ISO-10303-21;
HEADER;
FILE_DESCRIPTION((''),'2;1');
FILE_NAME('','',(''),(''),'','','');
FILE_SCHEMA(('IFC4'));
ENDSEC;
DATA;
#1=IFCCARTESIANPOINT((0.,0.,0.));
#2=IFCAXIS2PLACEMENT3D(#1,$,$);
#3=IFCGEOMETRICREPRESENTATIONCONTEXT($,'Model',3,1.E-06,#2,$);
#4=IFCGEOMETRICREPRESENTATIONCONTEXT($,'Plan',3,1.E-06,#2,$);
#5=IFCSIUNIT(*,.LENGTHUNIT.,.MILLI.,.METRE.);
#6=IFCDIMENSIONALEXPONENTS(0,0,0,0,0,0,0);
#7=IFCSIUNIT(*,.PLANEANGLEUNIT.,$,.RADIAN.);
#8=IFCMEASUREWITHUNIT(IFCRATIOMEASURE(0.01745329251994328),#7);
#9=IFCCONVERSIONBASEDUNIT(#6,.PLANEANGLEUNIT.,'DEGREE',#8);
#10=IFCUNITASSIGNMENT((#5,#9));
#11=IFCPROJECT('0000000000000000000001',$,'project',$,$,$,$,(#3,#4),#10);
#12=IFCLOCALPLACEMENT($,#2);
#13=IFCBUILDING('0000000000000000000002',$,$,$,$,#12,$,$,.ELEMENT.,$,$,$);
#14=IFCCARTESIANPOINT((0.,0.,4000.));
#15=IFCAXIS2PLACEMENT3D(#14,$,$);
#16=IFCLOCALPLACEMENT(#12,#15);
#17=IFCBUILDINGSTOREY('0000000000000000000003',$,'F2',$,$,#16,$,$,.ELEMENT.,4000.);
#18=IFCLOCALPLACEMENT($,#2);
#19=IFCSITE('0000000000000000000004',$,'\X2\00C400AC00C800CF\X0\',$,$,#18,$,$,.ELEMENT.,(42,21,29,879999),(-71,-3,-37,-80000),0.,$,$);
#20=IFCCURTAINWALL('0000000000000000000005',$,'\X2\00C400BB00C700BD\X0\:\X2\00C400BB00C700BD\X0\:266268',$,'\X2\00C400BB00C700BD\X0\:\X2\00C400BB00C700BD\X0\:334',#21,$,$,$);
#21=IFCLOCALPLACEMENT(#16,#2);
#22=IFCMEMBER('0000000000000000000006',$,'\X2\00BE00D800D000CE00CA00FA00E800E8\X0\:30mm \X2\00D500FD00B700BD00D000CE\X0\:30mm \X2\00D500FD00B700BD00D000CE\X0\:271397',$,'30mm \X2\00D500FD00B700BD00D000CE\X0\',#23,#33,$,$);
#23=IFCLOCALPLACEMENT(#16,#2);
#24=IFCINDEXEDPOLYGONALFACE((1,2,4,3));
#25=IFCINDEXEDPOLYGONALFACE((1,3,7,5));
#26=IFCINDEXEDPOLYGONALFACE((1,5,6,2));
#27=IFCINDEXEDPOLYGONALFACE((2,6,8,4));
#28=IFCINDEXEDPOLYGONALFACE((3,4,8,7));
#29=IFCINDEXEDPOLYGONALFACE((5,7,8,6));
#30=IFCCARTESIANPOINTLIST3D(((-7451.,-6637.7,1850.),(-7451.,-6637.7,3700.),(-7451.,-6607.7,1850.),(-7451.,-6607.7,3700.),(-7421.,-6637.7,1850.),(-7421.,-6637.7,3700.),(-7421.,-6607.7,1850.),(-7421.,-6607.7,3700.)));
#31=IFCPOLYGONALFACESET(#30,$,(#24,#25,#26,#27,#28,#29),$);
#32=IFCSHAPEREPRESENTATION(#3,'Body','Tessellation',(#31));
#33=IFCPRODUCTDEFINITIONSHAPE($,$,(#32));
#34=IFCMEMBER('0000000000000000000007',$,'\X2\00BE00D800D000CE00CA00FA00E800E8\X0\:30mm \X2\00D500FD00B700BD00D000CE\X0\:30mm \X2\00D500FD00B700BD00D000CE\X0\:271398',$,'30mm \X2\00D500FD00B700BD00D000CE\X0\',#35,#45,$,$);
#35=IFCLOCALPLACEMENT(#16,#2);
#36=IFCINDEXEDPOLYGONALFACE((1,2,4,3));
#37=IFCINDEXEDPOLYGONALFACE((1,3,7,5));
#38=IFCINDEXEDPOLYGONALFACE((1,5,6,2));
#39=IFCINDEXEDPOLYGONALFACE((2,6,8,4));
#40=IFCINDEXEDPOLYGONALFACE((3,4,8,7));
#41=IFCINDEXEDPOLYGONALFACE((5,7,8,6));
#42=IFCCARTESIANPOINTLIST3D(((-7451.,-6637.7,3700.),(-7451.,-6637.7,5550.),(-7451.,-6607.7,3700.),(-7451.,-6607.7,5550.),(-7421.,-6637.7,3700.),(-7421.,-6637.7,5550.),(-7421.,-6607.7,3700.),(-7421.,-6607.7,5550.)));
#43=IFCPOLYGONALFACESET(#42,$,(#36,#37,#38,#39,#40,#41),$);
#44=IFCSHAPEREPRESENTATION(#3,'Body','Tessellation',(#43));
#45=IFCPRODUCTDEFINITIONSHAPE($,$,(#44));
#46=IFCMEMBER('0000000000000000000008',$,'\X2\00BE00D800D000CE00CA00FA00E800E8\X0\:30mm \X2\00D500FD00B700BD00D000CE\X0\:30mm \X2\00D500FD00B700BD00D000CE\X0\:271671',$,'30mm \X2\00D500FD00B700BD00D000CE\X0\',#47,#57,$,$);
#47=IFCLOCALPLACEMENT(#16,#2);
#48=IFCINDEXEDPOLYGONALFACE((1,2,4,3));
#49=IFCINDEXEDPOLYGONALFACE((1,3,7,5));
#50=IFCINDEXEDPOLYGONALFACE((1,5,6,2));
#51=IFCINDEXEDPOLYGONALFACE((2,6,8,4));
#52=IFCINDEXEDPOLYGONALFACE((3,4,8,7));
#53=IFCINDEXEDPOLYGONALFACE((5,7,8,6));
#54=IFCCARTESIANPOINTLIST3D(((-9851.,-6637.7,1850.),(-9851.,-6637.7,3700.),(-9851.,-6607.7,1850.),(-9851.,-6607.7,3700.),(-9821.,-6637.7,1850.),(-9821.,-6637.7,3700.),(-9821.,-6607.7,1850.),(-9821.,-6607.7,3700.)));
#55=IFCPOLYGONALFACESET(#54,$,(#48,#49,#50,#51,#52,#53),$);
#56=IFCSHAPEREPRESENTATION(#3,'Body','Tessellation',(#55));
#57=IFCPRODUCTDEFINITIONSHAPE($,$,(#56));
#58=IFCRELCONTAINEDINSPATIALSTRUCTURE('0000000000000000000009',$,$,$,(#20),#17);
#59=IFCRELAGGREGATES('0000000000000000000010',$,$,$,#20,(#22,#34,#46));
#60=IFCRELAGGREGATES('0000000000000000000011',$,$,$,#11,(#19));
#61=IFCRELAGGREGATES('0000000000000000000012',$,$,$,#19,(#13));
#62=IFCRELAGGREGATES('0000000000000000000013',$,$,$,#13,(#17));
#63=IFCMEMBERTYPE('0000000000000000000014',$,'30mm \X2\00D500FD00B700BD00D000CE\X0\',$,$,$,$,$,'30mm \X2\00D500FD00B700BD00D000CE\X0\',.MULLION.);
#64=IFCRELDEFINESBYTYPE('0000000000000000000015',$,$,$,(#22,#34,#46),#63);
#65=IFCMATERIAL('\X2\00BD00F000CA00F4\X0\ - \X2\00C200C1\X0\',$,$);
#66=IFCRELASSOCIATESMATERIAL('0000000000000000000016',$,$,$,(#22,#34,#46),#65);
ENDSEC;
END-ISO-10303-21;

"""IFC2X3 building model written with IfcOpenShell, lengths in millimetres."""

from ifc_helpers import new_model, entity, si_unit, converted_unit, frame, origin, origin_2d_with_axis, place, context, project, spatial, rectangle, extrude, source, transform, mapped, material, type_object, type_shapes, element, aggregate, save


model = new_model("IFC2X3")

# Units and contexts
model_context = context("Model", 3, precision=1e-06, world=origin())
plan_context = context("Plan", 3, precision=1e-06, world=origin())
ifc_project = project(units=[si_unit("LENGTHUNIT", "METRE", prefix="MILLI"), converted_unit("PLANEANGLEUNIT", "DEGREE", entity("IfcRatioMeasure", 0.01745329251994328), si_unit("PLANEANGLEUNIT", "RADIAN"), dimensions=[0, 0, 0, 0, 0, 0, 0])], contexts=[model_context, plan_context])

# Site, building, storey
site_placement = place(None, origin())
site = spatial("IfcSite", under=ifc_project, at=site_placement, Name="Ä¬ÈÏ", CompositionType="ELEMENT", RefLatitude=(42, 21, 29, 879999), RefLongitude=(-71, -3, -37, -80000), RefElevation=0.0)
building_placement = place(None, origin())
building = spatial("IfcBuilding", under=site, at=building_placement, CompositionType="ELEMENT")
storey_placement = place(building_placement, frame((0.0, 0.0, 4000.0)))
storey = spatial("IfcBuildingStorey", under=building, at=storey_placement, Name="F2", CompositionType="ELEMENT", Elevation=4000.0)

# Curtain wall, members
curtain_wall_placement = place(storey_placement, origin())
curtain_wall = element("IfcCurtainWall", 1, at=curtain_wall_placement, inside=storey, Name="Ä»Ç½:Ä»Ç½:266268", ObjectType="Ä»Ç½:Ä»Ç½:334")
ifc_material_1 = material(Name="½ðÊô - ÂÁ")
placement = place(building_placement, frame((0.0, 0.0, 7700.0)))
member_type_1 = type_object("IfcMemberType", Name="30mm Õý·½ÐÎ", ElementType="30mm Õý·½ÐÎ", PredefinedType="MULLION")
shared_shape_1 = source(origin(), model_context, "Body", "SweptSolid", [
    extrude(rectangle(XDim=30.0, YDim=30.0, at=origin_2d_with_axis()), frame((0.0, 0.0, -1850.0), z_axis=(0.0, 0.0, 1.0), x_axis=(-1.0, 0.0, 0.0)), (0.0, 0.0, 1.0), 1850.0),
])
type_shapes(member_type_1, [shared_shape_1])
member_1_placement = place(storey_placement, frame((-7436.0, -6622.7, 1850.0), z_axis=(0.0, 0.0, -1.0), x_axis=(1.0, 0.0, 0.0)))
member_1 = element("IfcMember", 2, at=member_1_placement, type_object=member_type_1, material=ifc_material_1, Name="¾ØÐÎÊúèè:30mm Õý·½ÐÎ:30mm Õý·½ÐÎ:271397", ObjectType="30mm Õý·½ÐÎ", context=model_context, shape_type="MappedRepresentation", body=[
    mapped(shared_shape_1, transform((0.0, 0.0, 0.0), scale=1.0)),
])
member_2_placement = place(placement, frame((-7436.0, -6622.7, 0.0), z_axis=(0.0, 0.0, -1.0), x_axis=(1.0, 0.0, 0.0)))
member_2 = element("IfcMember", 3, at=member_2_placement, type_object=member_type_1, material=ifc_material_1, Name="¾ØÐÎÊúèè:30mm Õý·½ÐÎ:30mm Õý·½ÐÎ:271398", ObjectType="30mm Õý·½ÐÎ", context=model_context, shape_type="MappedRepresentation", body=[
    mapped(shared_shape_1, transform((0.0, 0.0, 0.0), scale=1.0)),
])
member_3_placement = place(storey_placement, frame((-9836.0, -6622.7, 1850.0), z_axis=(0.0, 0.0, -1.0), x_axis=(1.0, 0.0, 0.0)))
member_3 = element("IfcMember", 4, at=member_3_placement, type_object=member_type_1, material=ifc_material_1, Name="¾ØÐÎÊúèè:30mm Õý·½ÐÎ:30mm Õý·½ÐÎ:271671", ObjectType="30mm Õý·½ÐÎ", context=model_context, shape_type="MappedRepresentation", body=[
    mapped(shared_shape_1, transform((0.0, 0.0, 0.0), scale=1.0)),
])
aggregate(curtain_wall, [member_1, member_2, member_3])

save(model, "model.ifc")
